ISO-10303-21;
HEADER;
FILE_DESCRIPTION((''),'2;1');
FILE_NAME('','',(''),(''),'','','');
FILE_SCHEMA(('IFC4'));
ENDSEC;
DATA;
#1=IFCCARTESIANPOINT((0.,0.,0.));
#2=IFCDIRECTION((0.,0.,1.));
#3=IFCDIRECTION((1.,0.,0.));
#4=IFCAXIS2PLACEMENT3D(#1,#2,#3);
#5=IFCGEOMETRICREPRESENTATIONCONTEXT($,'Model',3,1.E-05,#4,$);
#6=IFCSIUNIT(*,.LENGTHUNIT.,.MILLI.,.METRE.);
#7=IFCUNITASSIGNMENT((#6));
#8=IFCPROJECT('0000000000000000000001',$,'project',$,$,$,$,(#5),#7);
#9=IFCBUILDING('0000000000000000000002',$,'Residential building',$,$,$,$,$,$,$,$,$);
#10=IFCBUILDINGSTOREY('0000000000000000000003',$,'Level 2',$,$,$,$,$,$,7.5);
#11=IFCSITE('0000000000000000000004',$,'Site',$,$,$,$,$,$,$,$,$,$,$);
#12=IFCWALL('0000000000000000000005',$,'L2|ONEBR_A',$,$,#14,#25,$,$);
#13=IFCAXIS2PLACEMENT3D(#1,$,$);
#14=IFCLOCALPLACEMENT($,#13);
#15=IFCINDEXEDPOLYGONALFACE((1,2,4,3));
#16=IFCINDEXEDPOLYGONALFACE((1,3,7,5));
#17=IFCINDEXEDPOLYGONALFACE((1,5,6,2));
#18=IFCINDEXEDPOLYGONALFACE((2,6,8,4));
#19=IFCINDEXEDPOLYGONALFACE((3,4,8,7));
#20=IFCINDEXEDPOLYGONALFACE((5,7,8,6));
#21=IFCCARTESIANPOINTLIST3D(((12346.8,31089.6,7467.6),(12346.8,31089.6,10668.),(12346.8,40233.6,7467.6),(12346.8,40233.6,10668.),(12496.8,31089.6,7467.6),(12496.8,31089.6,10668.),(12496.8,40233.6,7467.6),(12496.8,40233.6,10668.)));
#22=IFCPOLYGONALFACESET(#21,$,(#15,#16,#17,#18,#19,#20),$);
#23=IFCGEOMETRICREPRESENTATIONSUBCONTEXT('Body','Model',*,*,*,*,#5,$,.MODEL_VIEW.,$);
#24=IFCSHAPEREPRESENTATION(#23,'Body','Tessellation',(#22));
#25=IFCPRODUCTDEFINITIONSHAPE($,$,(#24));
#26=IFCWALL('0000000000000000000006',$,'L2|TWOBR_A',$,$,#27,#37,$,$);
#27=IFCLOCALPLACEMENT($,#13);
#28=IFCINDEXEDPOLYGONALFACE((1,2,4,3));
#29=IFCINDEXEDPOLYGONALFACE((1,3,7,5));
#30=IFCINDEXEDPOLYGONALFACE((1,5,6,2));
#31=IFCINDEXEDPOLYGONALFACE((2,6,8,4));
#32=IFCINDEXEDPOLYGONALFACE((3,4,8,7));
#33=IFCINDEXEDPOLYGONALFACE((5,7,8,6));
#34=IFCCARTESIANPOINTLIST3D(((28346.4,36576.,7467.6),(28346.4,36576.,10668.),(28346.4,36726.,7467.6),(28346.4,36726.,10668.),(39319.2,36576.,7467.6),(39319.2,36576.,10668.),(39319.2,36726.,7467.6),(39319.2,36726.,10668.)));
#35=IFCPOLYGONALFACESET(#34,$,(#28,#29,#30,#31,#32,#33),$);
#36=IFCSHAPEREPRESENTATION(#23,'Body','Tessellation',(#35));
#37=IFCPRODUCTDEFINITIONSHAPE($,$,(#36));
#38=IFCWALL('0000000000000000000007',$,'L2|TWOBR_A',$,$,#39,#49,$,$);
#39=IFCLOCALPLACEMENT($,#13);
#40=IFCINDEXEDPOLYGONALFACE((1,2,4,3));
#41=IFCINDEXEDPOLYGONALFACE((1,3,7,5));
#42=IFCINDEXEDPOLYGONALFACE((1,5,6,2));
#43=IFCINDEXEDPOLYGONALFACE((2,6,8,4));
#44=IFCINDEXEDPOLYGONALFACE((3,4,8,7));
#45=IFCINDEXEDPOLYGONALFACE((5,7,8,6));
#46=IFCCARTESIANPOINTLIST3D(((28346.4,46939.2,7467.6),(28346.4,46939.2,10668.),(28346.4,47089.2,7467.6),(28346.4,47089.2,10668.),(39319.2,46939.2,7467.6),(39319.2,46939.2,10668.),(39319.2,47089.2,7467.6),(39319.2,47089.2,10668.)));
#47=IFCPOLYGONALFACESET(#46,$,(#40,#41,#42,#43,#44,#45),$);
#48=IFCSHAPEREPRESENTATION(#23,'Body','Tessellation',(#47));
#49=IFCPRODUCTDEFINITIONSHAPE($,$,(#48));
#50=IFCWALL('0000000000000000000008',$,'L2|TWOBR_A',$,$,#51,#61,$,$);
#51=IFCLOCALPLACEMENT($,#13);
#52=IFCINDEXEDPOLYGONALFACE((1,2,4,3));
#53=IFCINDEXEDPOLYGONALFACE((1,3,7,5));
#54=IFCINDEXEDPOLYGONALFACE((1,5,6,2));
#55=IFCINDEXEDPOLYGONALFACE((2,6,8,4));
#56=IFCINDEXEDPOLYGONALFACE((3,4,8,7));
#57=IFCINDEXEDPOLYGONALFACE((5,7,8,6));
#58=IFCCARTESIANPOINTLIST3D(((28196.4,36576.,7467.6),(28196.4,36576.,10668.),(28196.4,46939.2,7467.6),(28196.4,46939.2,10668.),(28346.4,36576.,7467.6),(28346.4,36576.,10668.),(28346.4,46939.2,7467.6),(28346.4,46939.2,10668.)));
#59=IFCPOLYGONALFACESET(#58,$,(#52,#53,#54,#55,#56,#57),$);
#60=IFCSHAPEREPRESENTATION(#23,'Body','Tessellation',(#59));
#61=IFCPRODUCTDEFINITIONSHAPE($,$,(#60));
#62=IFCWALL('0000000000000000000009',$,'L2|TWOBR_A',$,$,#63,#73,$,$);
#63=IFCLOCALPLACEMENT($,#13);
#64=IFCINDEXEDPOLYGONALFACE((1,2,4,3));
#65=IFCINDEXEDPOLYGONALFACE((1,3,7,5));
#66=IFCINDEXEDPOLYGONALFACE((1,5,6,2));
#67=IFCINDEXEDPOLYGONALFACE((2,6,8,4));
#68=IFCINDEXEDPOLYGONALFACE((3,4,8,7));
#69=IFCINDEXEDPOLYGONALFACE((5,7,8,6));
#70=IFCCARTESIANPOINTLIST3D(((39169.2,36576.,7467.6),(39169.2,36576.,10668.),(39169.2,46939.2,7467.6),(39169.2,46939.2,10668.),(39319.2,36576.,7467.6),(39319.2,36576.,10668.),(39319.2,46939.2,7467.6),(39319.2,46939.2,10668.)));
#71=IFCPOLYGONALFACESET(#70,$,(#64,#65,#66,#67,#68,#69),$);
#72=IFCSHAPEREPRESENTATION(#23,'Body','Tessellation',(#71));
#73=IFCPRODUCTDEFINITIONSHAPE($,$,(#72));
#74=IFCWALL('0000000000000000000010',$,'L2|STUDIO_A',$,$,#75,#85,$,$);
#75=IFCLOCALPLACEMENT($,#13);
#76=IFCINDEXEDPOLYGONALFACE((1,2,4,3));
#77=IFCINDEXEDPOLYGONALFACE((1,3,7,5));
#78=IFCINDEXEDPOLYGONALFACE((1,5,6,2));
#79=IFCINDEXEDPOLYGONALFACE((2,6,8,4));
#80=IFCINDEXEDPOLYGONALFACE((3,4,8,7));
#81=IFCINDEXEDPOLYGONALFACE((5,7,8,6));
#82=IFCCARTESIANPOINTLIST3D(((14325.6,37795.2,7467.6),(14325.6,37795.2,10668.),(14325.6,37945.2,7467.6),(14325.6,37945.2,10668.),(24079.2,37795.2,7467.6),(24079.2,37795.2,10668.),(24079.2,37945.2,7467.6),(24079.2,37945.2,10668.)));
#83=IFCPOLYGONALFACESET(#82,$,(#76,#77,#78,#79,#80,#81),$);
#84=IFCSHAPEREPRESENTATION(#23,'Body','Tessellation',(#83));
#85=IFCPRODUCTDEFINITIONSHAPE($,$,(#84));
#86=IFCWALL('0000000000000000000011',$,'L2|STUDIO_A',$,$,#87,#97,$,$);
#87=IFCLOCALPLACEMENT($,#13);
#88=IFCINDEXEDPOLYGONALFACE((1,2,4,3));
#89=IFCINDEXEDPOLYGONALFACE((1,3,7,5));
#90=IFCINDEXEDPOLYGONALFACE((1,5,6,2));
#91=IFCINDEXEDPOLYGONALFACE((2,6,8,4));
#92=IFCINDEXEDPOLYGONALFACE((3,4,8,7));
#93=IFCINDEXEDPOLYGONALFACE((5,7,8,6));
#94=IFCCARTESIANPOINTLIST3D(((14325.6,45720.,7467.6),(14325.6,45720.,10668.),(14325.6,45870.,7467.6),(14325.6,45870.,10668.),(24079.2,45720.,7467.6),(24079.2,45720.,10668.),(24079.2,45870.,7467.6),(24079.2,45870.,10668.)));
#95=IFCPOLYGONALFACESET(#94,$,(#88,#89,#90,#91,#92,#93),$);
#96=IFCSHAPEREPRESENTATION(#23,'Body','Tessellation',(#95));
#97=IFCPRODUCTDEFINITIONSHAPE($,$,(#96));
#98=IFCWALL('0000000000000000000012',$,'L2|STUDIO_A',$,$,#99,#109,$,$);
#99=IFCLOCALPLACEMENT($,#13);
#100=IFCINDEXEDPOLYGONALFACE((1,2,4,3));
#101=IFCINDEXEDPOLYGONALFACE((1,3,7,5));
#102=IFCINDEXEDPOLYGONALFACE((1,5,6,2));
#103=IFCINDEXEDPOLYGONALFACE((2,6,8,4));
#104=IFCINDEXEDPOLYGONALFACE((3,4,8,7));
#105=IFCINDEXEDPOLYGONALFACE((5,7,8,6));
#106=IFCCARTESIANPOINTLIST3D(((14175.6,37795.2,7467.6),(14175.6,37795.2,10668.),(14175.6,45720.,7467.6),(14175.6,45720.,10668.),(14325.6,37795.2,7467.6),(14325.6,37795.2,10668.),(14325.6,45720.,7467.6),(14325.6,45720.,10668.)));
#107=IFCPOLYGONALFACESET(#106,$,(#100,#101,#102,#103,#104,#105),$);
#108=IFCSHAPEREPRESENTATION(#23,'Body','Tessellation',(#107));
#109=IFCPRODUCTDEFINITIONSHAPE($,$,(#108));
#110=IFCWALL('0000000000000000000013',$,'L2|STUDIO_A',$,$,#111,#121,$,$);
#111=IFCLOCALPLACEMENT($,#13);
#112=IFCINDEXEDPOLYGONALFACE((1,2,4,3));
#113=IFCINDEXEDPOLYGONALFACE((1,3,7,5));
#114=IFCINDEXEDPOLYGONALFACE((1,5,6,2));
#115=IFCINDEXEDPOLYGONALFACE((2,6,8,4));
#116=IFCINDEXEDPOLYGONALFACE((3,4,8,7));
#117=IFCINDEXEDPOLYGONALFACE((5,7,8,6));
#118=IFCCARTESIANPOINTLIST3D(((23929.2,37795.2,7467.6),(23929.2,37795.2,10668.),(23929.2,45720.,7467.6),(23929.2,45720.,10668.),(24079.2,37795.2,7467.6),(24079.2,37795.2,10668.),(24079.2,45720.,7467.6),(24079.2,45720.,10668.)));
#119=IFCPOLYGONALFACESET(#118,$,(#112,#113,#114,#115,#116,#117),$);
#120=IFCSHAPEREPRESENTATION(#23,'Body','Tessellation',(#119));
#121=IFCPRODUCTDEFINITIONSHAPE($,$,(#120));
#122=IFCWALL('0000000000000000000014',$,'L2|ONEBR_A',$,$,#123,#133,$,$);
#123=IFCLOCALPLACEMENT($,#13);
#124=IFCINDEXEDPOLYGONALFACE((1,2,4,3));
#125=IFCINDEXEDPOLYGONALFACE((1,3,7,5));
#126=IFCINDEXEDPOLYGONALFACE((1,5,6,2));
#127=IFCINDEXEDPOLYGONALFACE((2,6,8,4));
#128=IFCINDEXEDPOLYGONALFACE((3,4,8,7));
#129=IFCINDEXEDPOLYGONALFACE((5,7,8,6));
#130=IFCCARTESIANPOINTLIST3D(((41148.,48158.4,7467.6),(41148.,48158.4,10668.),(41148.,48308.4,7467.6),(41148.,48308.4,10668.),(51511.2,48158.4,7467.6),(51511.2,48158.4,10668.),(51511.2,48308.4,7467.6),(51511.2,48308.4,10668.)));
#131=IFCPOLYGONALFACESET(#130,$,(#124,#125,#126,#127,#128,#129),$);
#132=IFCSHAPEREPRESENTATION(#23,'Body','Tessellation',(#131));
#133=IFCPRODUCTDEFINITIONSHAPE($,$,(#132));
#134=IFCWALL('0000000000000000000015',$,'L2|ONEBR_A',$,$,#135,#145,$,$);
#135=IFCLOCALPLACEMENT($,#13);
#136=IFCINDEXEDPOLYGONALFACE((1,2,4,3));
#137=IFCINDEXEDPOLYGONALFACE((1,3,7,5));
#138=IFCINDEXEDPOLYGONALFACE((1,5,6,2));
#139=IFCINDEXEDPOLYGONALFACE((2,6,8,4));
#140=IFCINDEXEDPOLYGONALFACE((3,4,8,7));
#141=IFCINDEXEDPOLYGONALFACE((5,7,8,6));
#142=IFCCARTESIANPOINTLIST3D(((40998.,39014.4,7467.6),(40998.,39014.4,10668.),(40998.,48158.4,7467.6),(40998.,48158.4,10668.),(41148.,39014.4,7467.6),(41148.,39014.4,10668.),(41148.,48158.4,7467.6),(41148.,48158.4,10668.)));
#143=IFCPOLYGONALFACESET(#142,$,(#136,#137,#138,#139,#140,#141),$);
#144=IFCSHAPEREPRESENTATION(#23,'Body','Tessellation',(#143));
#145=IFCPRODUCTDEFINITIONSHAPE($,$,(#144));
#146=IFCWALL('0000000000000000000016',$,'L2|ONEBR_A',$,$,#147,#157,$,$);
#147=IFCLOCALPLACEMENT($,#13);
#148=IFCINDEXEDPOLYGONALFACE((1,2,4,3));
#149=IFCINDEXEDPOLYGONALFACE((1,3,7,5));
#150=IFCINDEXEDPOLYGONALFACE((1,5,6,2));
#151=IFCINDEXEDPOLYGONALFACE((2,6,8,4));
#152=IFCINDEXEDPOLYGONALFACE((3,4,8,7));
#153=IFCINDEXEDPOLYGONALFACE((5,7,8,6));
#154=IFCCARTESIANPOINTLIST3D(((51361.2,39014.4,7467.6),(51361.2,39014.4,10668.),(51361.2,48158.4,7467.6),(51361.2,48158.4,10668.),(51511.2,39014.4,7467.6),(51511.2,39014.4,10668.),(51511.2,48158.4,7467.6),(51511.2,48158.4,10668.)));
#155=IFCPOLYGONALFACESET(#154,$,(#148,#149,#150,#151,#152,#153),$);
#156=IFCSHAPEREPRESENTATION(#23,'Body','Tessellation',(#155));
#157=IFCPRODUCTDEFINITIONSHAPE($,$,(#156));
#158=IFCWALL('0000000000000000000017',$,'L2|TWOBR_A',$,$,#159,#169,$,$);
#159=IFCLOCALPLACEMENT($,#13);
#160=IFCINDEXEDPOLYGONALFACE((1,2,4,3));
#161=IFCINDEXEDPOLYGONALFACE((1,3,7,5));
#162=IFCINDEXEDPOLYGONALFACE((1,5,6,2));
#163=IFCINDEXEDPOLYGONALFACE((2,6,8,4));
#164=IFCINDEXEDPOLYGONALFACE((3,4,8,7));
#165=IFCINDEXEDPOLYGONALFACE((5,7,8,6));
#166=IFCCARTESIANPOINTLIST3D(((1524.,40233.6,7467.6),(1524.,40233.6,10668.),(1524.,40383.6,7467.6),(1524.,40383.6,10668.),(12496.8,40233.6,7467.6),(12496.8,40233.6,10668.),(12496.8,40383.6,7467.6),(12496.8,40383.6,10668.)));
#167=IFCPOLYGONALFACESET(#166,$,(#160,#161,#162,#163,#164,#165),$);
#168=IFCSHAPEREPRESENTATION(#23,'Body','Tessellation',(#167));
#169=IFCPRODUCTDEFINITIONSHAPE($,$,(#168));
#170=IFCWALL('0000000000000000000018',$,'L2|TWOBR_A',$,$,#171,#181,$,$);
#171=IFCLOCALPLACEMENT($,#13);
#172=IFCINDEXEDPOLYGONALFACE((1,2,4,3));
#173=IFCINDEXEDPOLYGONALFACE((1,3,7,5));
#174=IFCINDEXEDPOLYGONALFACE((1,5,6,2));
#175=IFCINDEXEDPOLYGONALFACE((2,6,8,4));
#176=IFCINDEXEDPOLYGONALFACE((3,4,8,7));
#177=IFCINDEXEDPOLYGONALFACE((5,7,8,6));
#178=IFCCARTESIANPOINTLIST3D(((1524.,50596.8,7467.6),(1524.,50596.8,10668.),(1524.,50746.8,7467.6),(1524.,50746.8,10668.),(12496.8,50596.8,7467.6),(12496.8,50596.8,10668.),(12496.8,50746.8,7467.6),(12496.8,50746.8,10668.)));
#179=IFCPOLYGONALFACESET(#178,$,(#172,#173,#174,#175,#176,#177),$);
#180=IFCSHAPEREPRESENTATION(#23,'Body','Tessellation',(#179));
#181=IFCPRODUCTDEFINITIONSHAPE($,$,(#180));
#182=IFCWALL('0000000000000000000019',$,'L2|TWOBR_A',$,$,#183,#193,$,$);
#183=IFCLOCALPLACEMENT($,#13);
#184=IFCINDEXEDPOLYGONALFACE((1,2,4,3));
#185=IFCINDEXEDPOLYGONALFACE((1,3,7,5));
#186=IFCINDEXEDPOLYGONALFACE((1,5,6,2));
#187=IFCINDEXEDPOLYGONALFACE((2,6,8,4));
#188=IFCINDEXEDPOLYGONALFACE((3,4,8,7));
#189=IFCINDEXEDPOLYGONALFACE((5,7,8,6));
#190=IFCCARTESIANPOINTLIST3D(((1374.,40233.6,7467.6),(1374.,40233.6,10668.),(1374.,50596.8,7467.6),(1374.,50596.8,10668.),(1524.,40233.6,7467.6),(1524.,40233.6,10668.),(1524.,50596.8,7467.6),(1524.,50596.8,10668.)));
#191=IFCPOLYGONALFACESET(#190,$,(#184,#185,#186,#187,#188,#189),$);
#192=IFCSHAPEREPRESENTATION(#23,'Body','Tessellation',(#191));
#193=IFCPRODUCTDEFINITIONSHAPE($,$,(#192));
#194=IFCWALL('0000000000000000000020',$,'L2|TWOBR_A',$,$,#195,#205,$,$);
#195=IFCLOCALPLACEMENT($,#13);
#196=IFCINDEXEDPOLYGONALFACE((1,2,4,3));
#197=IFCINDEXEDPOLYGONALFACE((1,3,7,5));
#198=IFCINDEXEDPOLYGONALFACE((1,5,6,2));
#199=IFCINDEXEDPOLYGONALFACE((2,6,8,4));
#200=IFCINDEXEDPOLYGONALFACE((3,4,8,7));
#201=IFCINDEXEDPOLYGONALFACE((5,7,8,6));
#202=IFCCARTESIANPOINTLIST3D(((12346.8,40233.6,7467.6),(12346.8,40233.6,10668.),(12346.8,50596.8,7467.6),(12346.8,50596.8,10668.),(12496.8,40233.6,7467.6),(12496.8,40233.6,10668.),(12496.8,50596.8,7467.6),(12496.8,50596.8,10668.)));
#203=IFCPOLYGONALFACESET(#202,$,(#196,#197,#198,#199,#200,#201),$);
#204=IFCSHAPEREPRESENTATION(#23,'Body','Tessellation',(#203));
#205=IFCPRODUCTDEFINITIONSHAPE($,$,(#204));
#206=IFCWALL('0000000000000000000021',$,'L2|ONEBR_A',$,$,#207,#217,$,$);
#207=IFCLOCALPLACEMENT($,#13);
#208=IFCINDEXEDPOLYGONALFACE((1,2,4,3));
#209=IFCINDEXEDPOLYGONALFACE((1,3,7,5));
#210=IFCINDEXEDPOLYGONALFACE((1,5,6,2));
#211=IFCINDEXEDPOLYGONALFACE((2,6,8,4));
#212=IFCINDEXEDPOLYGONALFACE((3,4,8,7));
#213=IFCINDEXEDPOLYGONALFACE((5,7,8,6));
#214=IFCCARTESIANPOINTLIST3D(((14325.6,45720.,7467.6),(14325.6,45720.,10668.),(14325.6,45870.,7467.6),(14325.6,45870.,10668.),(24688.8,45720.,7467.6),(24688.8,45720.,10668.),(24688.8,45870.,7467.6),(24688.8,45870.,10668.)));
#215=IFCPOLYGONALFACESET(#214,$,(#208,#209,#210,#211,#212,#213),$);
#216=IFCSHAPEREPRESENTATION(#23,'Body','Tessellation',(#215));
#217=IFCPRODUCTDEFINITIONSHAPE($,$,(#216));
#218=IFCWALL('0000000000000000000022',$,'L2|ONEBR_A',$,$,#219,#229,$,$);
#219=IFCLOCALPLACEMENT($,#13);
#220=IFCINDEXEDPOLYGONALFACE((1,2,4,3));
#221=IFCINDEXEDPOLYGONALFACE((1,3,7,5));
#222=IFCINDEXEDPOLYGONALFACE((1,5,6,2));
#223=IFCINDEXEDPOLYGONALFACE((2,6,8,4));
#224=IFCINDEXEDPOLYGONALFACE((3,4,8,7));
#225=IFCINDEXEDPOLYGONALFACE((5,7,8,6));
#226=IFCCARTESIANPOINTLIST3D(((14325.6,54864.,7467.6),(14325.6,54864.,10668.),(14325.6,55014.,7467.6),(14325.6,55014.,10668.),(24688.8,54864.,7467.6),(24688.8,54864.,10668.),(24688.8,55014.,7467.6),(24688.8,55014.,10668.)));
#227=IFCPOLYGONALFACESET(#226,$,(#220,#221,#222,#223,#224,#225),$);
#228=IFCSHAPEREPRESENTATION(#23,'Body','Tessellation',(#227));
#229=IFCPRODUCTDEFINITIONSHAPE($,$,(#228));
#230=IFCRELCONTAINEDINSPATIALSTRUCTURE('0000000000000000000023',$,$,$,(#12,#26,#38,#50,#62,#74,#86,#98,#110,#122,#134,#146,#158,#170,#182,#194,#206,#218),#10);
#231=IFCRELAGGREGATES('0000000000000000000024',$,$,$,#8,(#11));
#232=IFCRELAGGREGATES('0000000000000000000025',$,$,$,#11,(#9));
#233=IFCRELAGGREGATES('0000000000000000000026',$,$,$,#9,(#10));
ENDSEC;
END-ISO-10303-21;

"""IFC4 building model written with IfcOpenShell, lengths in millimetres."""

from ifc_helpers import new_model, si_unit, frame, origin_with_axes, place, context, subcontext, project, spatial, indexed_curve, outline, extrude, element, save


model = new_model("IFC4")

# Units and contexts
model_context = context("Model", 3, precision=1e-05, world=origin_with_axes())
body_context = subcontext(model_context, "Body", "Model", "MODEL_VIEW")
ifc_project = project(units=[si_unit("LENGTHUNIT", "METRE", prefix="MILLI")], contexts=[model_context])

# Site, building, storey
site = spatial("IfcSite", under=ifc_project, Name="Site")
building = spatial("IfcBuilding", under=site, Name="Residential building")
storey = spatial("IfcBuildingStorey", under=building, Name="Level 2", Elevation=7.5)

# Walls
for number, where, z_axis, x_axis, name in (
    (1, (12496.8, 31089.6, 7467.6), (0.0, 0.0, 1.0), (0.0, 1.0, 0.0), "L2|ONEBR_A"),
):
    element("IfcWall", number, at=place(None, frame(where, z_axis=z_axis, x_axis=x_axis)), inside=storey, Name=name, context=body_context, shape_type="SweptSolid", body=[
        extrude(outline(indexed_curve([(0.0, 0.0), (0.0, 150.0), (9144.0, 150.0), (9144.0, 0.0), (0.0, 0.0)], self_intersect=False)), origin_with_axes(), (0.0, 0.0, 1.0), 3200.4),
    ])
for number, where, z_axis, x_axis, name in (
    (2, (28346.4, 36576.0, 7467.6), (0.0, 0.0, 1.0), (1.0, 0.0, 0.0), "L2|TWOBR_A"),
    (3, (28346.4, 46939.2, 7467.6), (0.0, 0.0, 1.0), (1.0, 0.0, 0.0), "L2|TWOBR_A"),
):
    element("IfcWall", number, at=place(None, frame(where, z_axis=z_axis, x_axis=x_axis)), inside=storey, Name=name, context=body_context, shape_type="SweptSolid", body=[
        extrude(outline(indexed_curve([(0.0, 0.0), (0.0, 150.0), (10972.8, 150.0), (10972.8, 0.0), (0.0, 0.0)], self_intersect=False)), origin_with_axes(), (0.0, 0.0, 1.0), 3200.4),
    ])
for number, where, z_axis, x_axis, name in (
    (4, (28346.4, 36576.0, 7467.6), (0.0, 0.0, 1.0), (0.0, 1.0, 0.0), "L2|TWOBR_A"),
    (5, (39319.2, 36576.0, 7467.6), (0.0, 0.0, 1.0), (0.0, 1.0, 0.0), "L2|TWOBR_A"),
):
    element("IfcWall", number, at=place(None, frame(where, z_axis=z_axis, x_axis=x_axis)), inside=storey, Name=name, context=body_context, shape_type="SweptSolid", body=[
        extrude(outline(indexed_curve([(0.0, 0.0), (0.0, 150.0), (10363.2, 150.0), (10363.2, 0.0), (0.0, 0.0)], self_intersect=False)), origin_with_axes(), (0.0, 0.0, 1.0), 3200.4),
    ])
for number, where, z_axis, x_axis, name in (
    (6, (14325.6, 37795.2, 7467.6), (0.0, 0.0, 1.0), (1.0, 0.0, 0.0), "L2|STUDIO_A"),
    (7, (14325.6, 45720.0, 7467.6), (0.0, 0.0, 1.0), (1.0, 0.0, 0.0), "L2|STUDIO_A"),
):
    element("IfcWall", number, at=place(None, frame(where, z_axis=z_axis, x_axis=x_axis)), inside=storey, Name=name, context=body_context, shape_type="SweptSolid", body=[
        extrude(outline(indexed_curve([(0.0, 0.0), (0.0, 150.0), (9753.6, 150.0), (9753.6, 0.0), (0.0, 0.0)], self_intersect=False)), origin_with_axes(), (0.0, 0.0, 1.0), 3200.4),
    ])
for number, where, z_axis, x_axis, name in (
    (8, (14325.6, 37795.2, 7467.6), (0.0, 0.0, 1.0), (0.0, 1.0, 0.0), "L2|STUDIO_A"),
    (9, (24079.2, 37795.2, 7467.6), (0.0, 0.0, 1.0), (0.0, 1.0, 0.0), "L2|STUDIO_A"),
):
    element("IfcWall", number, at=place(None, frame(where, z_axis=z_axis, x_axis=x_axis)), inside=storey, Name=name, context=body_context, shape_type="SweptSolid", body=[
        extrude(outline(indexed_curve([(0.0, 0.0), (0.0, 150.0), (7924.8, 150.0), (7924.8, 0.0), (0.0, 0.0)], self_intersect=False)), origin_with_axes(), (0.0, 0.0, 1.0), 3200.4),
    ])
for number, where, z_axis, x_axis, name in (
    (10, (41148.0, 48158.4, 7467.6), (0.0, 0.0, 1.0), (1.0, 0.0, 0.0), "L2|ONEBR_A"),
):
    element("IfcWall", number, at=place(None, frame(where, z_axis=z_axis, x_axis=x_axis)), inside=storey, Name=name, context=body_context, shape_type="SweptSolid", body=[
        extrude(outline(indexed_curve([(0.0, 0.0), (0.0, 150.0), (10363.2, 150.0), (10363.2, 0.0), (0.0, 0.0)], self_intersect=False)), origin_with_axes(), (0.0, 0.0, 1.0), 3200.4),
    ])
for number, where, z_axis, x_axis, name in (
    (11, (41148.0, 39014.4, 7467.6), (0.0, 0.0, 1.0), (0.0, 1.0, 0.0), "L2|ONEBR_A"),
    (12, (51511.2, 39014.4, 7467.6), (0.0, 0.0, 1.0), (0.0, 1.0, 0.0), "L2|ONEBR_A"),
):
    element("IfcWall", number, at=place(None, frame(where, z_axis=z_axis, x_axis=x_axis)), inside=storey, Name=name, context=body_context, shape_type="SweptSolid", body=[
        extrude(outline(indexed_curve([(0.0, 0.0), (0.0, 150.0), (9144.0, 150.0), (9144.0, 0.0), (0.0, 0.0)], self_intersect=False)), origin_with_axes(), (0.0, 0.0, 1.0), 3200.4),
    ])
for number, where, z_axis, x_axis, name in (
    (13, (1524.0, 40233.6, 7467.6), (0.0, 0.0, 1.0), (1.0, 0.0, 0.0), "L2|TWOBR_A"),
    (14, (1524.0, 50596.8, 7467.6), (0.0, 0.0, 1.0), (1.0, 0.0, 0.0), "L2|TWOBR_A"),
):
    element("IfcWall", number, at=place(None, frame(where, z_axis=z_axis, x_axis=x_axis)), inside=storey, Name=name, context=body_context, shape_type="SweptSolid", body=[
        extrude(outline(indexed_curve([(0.0, 0.0), (0.0, 150.0), (10972.8, 150.0), (10972.8, 0.0), (0.0, 0.0)], self_intersect=False)), origin_with_axes(), (0.0, 0.0, 1.0), 3200.4),
    ])
for number, where, z_axis, x_axis, name in (
    (15, (1524.0, 40233.6, 7467.6), (0.0, 0.0, 1.0), (0.0, 1.0, 0.0), "L2|TWOBR_A"),
    (16, (12496.8, 40233.6, 7467.6), (0.0, 0.0, 1.0), (0.0, 1.0, 0.0), "L2|TWOBR_A"),
    (17, (14325.6, 45720.0, 7467.6), (0.0, 0.0, 1.0), (1.0, 0.0, 0.0), "L2|ONEBR_A"),
    (18, (14325.6, 54864.0, 7467.6), (0.0, 0.0, 1.0), (1.0, 0.0, 0.0), "L2|ONEBR_A"),
):
    element("IfcWall", number, at=place(None, frame(where, z_axis=z_axis, x_axis=x_axis)), inside=storey, Name=name, context=body_context, shape_type="SweptSolid", body=[
        extrude(outline(indexed_curve([(0.0, 0.0), (0.0, 150.0), (10363.2, 150.0), (10363.2, 0.0), (0.0, 0.0)], self_intersect=False)), origin_with_axes(), (0.0, 0.0, 1.0), 3200.4),
    ])

save(model, "model.ifc")
